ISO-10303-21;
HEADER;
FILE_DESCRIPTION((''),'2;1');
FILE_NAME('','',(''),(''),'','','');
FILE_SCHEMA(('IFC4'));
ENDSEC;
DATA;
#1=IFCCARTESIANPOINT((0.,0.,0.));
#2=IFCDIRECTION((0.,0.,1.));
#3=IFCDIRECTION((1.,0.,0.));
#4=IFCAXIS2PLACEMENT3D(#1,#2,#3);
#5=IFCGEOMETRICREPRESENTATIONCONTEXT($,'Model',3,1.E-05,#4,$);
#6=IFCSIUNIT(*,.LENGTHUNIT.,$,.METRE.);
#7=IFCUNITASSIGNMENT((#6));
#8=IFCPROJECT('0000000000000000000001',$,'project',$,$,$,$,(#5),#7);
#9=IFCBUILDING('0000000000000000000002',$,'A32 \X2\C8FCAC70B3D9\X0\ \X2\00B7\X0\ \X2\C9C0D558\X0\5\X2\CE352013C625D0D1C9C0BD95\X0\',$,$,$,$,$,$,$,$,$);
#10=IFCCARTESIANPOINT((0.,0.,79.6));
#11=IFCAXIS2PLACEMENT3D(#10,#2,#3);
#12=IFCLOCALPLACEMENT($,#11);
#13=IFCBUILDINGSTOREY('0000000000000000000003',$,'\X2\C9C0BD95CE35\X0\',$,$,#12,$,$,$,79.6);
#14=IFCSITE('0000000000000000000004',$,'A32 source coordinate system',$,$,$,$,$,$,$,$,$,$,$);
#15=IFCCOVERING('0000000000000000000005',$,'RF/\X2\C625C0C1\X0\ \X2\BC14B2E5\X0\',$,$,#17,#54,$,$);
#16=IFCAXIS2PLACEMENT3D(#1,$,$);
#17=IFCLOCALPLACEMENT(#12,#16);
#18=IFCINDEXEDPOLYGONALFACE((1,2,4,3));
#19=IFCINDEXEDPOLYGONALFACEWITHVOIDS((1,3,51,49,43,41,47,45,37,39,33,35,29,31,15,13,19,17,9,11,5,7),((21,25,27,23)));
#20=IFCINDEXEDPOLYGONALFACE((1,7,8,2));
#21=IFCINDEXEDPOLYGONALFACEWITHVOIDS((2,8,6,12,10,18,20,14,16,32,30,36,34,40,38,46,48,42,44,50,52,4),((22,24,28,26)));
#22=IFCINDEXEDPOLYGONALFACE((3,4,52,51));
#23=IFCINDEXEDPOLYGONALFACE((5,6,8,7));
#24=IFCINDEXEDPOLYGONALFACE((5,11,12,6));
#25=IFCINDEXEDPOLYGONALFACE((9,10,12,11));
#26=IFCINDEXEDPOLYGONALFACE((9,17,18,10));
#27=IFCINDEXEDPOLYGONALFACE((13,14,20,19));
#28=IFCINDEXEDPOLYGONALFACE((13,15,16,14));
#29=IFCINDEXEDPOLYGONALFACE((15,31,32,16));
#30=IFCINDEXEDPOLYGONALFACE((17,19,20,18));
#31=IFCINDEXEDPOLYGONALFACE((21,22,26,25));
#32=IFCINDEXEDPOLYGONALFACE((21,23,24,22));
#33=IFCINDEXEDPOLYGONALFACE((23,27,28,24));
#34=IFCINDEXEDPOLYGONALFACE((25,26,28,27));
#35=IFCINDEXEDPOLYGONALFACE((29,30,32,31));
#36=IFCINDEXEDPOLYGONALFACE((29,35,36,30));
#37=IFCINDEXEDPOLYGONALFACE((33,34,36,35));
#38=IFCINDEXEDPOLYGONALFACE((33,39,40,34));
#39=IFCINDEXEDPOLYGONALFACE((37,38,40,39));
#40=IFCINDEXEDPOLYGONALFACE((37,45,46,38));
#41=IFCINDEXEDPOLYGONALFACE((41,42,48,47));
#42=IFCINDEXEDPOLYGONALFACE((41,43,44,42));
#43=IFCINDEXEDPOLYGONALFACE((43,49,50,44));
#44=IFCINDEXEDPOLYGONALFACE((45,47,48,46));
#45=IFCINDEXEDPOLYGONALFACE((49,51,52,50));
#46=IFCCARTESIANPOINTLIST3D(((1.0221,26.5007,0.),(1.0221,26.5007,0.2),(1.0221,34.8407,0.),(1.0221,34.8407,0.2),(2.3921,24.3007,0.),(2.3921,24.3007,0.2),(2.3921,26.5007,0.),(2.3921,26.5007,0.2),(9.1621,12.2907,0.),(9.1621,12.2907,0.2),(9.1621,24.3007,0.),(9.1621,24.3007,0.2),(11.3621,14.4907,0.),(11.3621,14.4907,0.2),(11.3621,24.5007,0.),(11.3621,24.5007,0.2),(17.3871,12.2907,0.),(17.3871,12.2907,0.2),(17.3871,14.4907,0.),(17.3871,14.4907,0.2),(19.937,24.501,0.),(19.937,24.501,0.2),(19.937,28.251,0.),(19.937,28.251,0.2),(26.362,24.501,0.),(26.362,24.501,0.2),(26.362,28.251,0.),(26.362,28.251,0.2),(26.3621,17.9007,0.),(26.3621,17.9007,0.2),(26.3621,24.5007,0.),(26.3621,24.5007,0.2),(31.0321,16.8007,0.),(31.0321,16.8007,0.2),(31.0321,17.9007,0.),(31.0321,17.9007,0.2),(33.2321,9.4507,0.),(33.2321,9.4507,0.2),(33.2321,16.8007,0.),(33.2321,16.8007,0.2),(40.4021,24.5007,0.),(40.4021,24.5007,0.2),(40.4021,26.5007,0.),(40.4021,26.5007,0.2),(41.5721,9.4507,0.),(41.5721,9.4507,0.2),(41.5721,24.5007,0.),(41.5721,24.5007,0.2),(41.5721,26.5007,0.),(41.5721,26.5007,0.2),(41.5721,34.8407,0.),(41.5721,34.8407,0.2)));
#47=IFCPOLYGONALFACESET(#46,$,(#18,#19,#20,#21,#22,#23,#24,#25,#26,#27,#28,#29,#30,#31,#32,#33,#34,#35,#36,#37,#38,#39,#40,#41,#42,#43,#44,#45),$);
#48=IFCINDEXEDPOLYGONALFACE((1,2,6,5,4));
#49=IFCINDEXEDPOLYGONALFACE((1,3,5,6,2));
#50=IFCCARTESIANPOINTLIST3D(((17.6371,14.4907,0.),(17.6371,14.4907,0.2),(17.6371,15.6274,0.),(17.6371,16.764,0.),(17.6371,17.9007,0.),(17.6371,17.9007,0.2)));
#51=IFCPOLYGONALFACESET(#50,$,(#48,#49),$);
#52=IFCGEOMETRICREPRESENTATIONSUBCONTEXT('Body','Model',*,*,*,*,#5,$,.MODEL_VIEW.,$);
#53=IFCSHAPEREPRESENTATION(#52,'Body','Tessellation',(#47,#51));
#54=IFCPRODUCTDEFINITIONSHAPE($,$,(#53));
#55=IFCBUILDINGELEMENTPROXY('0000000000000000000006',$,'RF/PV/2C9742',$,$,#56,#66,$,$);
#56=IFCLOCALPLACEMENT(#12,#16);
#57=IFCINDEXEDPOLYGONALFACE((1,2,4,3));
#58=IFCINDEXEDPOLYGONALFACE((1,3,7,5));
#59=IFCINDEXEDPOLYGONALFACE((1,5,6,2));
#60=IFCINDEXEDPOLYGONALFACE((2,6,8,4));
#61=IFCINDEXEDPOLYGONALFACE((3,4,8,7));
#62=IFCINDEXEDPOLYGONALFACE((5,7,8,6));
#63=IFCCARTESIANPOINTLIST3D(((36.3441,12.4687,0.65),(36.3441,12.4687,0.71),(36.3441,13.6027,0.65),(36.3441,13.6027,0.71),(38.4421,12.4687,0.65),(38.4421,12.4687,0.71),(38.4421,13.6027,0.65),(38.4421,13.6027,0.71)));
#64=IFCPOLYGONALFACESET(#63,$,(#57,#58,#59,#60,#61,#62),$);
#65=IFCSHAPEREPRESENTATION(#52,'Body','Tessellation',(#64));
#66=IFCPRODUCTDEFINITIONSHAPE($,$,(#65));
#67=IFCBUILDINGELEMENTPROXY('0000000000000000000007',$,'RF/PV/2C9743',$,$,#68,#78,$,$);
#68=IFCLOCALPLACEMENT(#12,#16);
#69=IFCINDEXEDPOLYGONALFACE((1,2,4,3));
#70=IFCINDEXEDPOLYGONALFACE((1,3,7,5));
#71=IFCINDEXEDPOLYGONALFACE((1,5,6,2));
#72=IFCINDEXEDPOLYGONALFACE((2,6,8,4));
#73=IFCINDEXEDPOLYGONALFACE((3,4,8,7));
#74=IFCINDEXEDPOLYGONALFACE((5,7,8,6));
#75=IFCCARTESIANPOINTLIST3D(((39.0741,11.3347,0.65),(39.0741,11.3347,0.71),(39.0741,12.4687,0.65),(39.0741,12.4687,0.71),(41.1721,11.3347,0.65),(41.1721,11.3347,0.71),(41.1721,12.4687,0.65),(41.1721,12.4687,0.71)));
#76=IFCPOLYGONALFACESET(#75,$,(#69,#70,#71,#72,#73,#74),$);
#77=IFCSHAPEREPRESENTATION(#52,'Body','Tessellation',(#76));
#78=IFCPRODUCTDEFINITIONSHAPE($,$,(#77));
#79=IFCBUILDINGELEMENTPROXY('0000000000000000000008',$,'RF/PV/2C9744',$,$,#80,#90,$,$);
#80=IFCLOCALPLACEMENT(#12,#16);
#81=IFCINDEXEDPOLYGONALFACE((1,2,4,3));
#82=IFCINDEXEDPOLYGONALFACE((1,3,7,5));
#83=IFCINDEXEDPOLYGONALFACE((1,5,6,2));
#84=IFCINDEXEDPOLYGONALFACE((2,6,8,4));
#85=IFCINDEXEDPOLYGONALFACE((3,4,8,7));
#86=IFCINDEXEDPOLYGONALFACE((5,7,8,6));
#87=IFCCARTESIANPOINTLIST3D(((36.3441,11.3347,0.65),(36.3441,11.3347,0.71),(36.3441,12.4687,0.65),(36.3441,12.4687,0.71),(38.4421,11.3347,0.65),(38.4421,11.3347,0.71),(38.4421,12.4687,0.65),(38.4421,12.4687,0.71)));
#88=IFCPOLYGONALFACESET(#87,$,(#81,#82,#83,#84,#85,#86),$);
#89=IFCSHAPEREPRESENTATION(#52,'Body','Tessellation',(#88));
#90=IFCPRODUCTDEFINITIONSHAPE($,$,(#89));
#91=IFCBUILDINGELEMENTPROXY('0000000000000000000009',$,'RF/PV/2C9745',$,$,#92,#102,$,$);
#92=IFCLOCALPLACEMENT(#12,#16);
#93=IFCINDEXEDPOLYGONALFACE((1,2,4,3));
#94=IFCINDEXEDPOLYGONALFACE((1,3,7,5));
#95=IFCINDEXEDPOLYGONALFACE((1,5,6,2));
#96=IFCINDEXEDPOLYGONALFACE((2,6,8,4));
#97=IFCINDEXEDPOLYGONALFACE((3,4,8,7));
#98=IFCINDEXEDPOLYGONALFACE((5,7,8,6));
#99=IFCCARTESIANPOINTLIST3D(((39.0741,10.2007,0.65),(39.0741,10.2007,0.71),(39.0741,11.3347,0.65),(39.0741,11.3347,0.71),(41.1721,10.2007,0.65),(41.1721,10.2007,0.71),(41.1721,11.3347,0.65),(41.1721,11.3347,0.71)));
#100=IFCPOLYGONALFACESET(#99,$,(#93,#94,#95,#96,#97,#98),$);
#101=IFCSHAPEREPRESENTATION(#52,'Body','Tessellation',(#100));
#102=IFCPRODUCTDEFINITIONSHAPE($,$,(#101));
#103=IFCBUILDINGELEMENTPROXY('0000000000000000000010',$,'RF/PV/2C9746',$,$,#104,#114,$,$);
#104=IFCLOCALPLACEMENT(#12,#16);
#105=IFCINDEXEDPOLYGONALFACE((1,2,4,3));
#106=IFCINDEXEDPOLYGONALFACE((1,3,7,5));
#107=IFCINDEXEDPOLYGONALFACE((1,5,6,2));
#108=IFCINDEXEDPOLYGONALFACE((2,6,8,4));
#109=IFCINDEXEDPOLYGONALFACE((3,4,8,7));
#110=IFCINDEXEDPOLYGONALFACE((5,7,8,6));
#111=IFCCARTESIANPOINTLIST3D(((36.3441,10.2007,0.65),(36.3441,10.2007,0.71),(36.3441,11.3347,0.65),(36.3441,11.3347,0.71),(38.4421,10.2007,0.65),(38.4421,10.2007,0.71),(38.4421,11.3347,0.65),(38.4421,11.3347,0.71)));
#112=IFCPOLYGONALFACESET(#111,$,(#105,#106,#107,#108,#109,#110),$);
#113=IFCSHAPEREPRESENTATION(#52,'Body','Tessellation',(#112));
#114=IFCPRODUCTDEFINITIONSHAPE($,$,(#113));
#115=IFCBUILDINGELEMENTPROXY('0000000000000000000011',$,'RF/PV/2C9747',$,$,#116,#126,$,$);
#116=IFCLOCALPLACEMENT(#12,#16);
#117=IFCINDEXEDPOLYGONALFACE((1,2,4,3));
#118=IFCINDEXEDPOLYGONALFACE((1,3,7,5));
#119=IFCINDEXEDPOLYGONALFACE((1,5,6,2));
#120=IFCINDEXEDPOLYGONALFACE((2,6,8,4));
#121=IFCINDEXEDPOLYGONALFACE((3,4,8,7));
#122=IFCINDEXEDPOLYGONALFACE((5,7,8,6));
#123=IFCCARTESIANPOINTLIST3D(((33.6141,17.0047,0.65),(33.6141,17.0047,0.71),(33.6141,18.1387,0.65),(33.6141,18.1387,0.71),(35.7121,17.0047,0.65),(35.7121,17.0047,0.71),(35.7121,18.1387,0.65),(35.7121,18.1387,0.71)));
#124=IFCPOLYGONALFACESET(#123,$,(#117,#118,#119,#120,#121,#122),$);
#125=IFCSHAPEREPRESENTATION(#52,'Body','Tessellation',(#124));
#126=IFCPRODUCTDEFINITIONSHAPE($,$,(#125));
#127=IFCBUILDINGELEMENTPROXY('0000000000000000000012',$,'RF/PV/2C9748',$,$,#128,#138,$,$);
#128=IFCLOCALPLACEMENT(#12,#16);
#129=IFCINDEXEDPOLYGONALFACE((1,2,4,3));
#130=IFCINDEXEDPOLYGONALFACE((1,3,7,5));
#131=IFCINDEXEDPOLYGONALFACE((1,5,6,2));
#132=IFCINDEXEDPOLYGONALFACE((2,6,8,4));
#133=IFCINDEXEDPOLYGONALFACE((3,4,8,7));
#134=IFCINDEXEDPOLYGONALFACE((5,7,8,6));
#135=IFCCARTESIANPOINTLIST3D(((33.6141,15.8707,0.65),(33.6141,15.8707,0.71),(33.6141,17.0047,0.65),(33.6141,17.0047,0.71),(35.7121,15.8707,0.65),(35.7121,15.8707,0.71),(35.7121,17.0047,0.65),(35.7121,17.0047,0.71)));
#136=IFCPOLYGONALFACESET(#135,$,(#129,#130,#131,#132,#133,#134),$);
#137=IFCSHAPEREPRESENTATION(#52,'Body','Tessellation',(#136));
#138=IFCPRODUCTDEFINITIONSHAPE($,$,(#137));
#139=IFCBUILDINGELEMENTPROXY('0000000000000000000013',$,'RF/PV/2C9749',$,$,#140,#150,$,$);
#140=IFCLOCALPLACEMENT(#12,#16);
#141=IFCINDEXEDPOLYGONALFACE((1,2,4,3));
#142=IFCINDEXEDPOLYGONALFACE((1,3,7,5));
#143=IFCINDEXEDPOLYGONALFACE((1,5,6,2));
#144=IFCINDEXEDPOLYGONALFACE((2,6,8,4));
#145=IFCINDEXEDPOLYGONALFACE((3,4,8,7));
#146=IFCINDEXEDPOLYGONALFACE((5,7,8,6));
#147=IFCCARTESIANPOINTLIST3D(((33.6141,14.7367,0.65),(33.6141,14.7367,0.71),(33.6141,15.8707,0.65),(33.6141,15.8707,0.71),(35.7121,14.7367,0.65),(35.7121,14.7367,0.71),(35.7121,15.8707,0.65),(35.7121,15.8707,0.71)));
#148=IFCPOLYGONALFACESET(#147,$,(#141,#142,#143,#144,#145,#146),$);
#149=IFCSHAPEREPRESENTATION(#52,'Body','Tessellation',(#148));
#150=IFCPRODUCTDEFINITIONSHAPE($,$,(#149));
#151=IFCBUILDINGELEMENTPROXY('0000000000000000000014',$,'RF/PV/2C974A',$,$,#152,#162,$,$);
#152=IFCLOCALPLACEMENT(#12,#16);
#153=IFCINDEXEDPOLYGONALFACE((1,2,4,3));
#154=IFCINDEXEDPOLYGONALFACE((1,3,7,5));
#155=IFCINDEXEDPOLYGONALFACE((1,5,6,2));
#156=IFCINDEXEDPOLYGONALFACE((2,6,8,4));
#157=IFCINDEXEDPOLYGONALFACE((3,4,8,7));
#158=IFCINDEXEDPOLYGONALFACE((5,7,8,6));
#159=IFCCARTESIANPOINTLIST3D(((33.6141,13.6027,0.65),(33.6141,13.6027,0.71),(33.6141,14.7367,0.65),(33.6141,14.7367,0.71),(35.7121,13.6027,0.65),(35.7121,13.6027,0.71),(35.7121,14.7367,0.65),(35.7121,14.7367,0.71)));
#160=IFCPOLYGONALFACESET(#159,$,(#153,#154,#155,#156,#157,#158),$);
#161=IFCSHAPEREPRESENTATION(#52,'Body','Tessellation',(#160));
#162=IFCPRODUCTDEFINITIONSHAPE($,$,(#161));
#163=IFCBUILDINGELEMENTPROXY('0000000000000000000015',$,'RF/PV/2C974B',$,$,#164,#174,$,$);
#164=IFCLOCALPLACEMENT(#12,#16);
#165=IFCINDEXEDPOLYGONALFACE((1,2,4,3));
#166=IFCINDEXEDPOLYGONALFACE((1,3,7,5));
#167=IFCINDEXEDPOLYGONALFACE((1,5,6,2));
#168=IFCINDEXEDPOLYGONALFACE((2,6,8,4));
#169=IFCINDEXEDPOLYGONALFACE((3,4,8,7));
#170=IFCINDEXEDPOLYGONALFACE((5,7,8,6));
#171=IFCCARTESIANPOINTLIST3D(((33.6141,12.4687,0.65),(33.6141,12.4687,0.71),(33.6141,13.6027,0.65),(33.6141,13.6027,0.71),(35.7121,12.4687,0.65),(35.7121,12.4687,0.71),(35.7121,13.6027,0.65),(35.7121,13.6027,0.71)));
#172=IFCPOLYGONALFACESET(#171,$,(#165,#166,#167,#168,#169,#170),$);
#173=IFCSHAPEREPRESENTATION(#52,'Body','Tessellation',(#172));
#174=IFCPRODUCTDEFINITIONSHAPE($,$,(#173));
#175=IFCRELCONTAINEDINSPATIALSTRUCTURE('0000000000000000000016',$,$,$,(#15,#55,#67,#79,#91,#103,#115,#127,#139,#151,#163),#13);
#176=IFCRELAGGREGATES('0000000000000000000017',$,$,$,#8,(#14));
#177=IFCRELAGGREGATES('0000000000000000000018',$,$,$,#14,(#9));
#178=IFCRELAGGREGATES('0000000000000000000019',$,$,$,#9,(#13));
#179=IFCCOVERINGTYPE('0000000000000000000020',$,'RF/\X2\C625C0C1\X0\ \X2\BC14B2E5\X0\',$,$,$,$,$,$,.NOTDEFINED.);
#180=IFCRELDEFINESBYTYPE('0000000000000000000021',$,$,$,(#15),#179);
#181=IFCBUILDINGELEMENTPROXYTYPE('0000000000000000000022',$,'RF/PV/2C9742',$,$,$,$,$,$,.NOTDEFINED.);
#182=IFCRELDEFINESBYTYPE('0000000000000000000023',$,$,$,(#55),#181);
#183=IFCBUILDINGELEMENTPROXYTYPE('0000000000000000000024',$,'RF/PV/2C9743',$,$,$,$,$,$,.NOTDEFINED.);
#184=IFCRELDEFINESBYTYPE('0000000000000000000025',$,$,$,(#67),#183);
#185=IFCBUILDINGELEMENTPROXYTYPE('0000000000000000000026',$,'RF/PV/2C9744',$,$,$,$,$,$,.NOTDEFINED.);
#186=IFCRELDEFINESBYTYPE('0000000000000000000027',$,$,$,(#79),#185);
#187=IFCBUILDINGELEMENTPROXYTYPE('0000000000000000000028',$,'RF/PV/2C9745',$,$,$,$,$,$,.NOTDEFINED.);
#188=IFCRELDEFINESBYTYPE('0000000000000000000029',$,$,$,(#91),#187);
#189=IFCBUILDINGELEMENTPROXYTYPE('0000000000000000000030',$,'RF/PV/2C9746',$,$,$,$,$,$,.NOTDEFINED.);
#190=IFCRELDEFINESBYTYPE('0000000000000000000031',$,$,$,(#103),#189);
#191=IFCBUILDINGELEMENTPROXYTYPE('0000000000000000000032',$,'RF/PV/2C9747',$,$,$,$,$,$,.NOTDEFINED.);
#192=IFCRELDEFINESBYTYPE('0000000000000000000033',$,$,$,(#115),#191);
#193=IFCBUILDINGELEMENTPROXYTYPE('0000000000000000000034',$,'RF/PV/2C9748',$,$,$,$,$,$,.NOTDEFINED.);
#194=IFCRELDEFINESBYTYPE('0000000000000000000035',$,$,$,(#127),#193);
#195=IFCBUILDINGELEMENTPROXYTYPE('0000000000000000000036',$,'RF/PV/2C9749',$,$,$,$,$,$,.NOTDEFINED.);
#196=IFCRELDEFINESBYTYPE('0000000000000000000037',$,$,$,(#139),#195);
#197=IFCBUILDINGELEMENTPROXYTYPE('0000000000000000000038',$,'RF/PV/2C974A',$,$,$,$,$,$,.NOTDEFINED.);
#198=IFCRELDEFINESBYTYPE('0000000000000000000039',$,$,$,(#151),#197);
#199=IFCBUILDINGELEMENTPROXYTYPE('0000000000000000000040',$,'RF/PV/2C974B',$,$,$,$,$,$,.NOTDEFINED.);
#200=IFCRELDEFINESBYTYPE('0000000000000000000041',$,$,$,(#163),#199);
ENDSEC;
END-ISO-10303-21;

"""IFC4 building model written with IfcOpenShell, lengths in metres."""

from ifc_helpers import new_model, si_unit, frame, origin, origin_with_axes, place, context, subcontext, project, spatial, polyline, outline, extrude, source, transform, mapped, type_object, type_shapes, element, save


model = new_model("IFC4")

# Units and contexts
model_context = context("Model", 3, precision=1e-05, world=origin_with_axes())
body_context = subcontext(model_context, "Body", "Model", "MODEL_VIEW")
ifc_project = project(units=[si_unit("LENGTHUNIT", "METRE")], contexts=[model_context])

# Site, building, storey
site = spatial("IfcSite", under=ifc_project, Name="A32 source coordinate system")
building = spatial("IfcBuilding", under=site, Name="A32 주거동 · 지하5층–옥탑지붕")
storey_placement = place(None, frame((0.0, 0.0, 79.6), z_axis=(0.0, 0.0, 1.0), x_axis=(1.0, 0.0, 0.0)))
storey = spatial("IfcBuildingStorey", under=building, at=storey_placement, Name="지붕층", Elevation=79.6)

# Covering
covering_type = type_object("IfcCoveringType", Name="RF/옥상 바닥", PredefinedType="NOTDEFINED")
shared_shape_1 = source(origin(), body_context, "Body", "SweptSolid", [
    extrude(outline(polyline([(9.1621, 12.2907), (9.1621, 24.3007), (2.3921, 24.3007), (2.3921, 26.5007), (1.0221, 26.5007), (1.0221, 34.8407), (41.5721, 34.8407), (41.5721, 26.5007), (40.4021, 26.5007), (40.4021, 24.5007), (41.5721, 24.5007), (41.5721, 9.4507), (33.2321, 9.4507), (33.2321, 16.8007), (31.0321, 16.8007), (31.0321, 17.9007), (26.3621, 17.9007), (26.3621, 17.9007), (26.3621, 24.5007), (11.3621, 24.5007), (11.3621, 14.4907), (17.3871, 14.4907), (17.3871, 14.4907), (17.3871, 12.2907), (9.1621, 12.2907)]), holes=[polyline([(26.362, 28.251), (19.937, 28.251), (19.937, 24.501), (26.362, 24.501), (26.362, 28.251)])]), origin(), (0.0, 0.0, 1.0), 0.2),
    extrude(outline(polyline([(17.6371, 14.4907), (17.6371, 17.9007), (17.6371, 17.9007), (17.6371, 14.4907), (17.6371, 14.4907)])), origin(), (0.0, 0.0, 1.0), 0.2),
])
type_shapes(covering_type, [shared_shape_1])
covering_placement = place(storey_placement, origin_with_axes())
element("IfcCovering", 1, at=covering_placement, inside=storey, type_object=covering_type, Name="RF/옥상 바닥", context=body_context, shape_type="MappedRepresentation", body=[
    mapped(shared_shape_1, transform((0.0, 0.0, 0.0), scale=1.0)),
])

# Building element proxies
building_element_proxy_type_1 = type_object("IfcBuildingElementProxyType", Name="RF/PV/2C9742", PredefinedType="NOTDEFINED")
shared_shape_2 = source(origin(), body_context, "Body", "SweptSolid", [
    extrude(outline(polyline([(38.4421, 13.6027), (38.4421, 12.4687), (36.3441, 12.4687), (36.3441, 13.6027), (38.4421, 13.6027)])), frame((0.0, 0.0, 0.65)), (0.0, 0.0, 1.0), 0.06),
])
type_shapes(building_element_proxy_type_1, [shared_shape_2])
proxy_1_placement = place(storey_placement, origin_with_axes())
element("IfcBuildingElementProxy", 2, at=proxy_1_placement, inside=storey, type_object=building_element_proxy_type_1, Name="RF/PV/2C9742", context=body_context, shape_type="MappedRepresentation", body=[
    mapped(shared_shape_2, transform((0.0, 0.0, 0.0), scale=1.0)),
])
building_element_proxy_type_2 = type_object("IfcBuildingElementProxyType", Name="RF/PV/2C9743", PredefinedType="NOTDEFINED")
shared_shape_3 = source(origin(), body_context, "Body", "SweptSolid", [
    extrude(outline(polyline([(41.1721, 12.4687), (41.1721, 11.3347), (39.0741, 11.3347), (39.0741, 12.4687), (41.1721, 12.4687)])), frame((0.0, 0.0, 0.65)), (0.0, 0.0, 1.0), 0.06),
])
type_shapes(building_element_proxy_type_2, [shared_shape_3])
proxy_2_placement = place(storey_placement, origin_with_axes())
element("IfcBuildingElementProxy", 3, at=proxy_2_placement, inside=storey, type_object=building_element_proxy_type_2, Name="RF/PV/2C9743", context=body_context, shape_type="MappedRepresentation", body=[
    mapped(shared_shape_3, transform((0.0, 0.0, 0.0), scale=1.0)),
])
building_element_proxy_type_3 = type_object("IfcBuildingElementProxyType", Name="RF/PV/2C9744", PredefinedType="NOTDEFINED")
shared_shape_4 = source(origin(), body_context, "Body", "SweptSolid", [
    extrude(outline(polyline([(38.4421, 12.4687), (38.4421, 11.3347), (36.3441, 11.3347), (36.3441, 12.4687), (38.4421, 12.4687)])), frame((0.0, 0.0, 0.65)), (0.0, 0.0, 1.0), 0.06),
])
type_shapes(building_element_proxy_type_3, [shared_shape_4])
proxy_3_placement = place(storey_placement, origin_with_axes())
element("IfcBuildingElementProxy", 4, at=proxy_3_placement, inside=storey, type_object=building_element_proxy_type_3, Name="RF/PV/2C9744", context=body_context, shape_type="MappedRepresentation", body=[
    mapped(shared_shape_4, transform((0.0, 0.0, 0.0), scale=1.0)),
])
building_element_proxy_type_4 = type_object("IfcBuildingElementProxyType", Name="RF/PV/2C9745", PredefinedType="NOTDEFINED")
shared_shape_5 = source(origin(), body_context, "Body", "SweptSolid", [
    extrude(outline(polyline([(41.1721, 11.3347), (41.1721, 10.2007), (39.0741, 10.2007), (39.0741, 11.3347), (41.1721, 11.3347)])), frame((0.0, 0.0, 0.65)), (0.0, 0.0, 1.0), 0.06),
])
type_shapes(building_element_proxy_type_4, [shared_shape_5])
proxy_4_placement = place(storey_placement, origin_with_axes())
element("IfcBuildingElementProxy", 5, at=proxy_4_placement, inside=storey, type_object=building_element_proxy_type_4, Name="RF/PV/2C9745", context=body_context, shape_type="MappedRepresentation", body=[
    mapped(shared_shape_5, transform((0.0, 0.0, 0.0), scale=1.0)),
])
building_element_proxy_type_5 = type_object("IfcBuildingElementProxyType", Name="RF/PV/2C9746", PredefinedType="NOTDEFINED")
shared_shape_6 = source(origin(), body_context, "Body", "SweptSolid", [
    extrude(outline(polyline([(38.4421, 11.3347), (38.4421, 10.2007), (36.3441, 10.2007), (36.3441, 11.3347), (38.4421, 11.3347)])), frame((0.0, 0.0, 0.65)), (0.0, 0.0, 1.0), 0.06),
])
type_shapes(building_element_proxy_type_5, [shared_shape_6])
proxy_5_placement = place(storey_placement, origin_with_axes())
element("IfcBuildingElementProxy", 6, at=proxy_5_placement, inside=storey, type_object=building_element_proxy_type_5, Name="RF/PV/2C9746", context=body_context, shape_type="MappedRepresentation", body=[
    mapped(shared_shape_6, transform((0.0, 0.0, 0.0), scale=1.0)),
])
building_element_proxy_type_6 = type_object("IfcBuildingElementProxyType", Name="RF/PV/2C9747", PredefinedType="NOTDEFINED")
shared_shape_7 = source(origin(), body_context, "Body", "SweptSolid", [
    extrude(outline(polyline([(35.7121, 18.1387), (35.7121, 17.0047), (33.6141, 17.0047), (33.6141, 18.1387), (35.7121, 18.1387)])), frame((0.0, 0.0, 0.65)), (0.0, 0.0, 1.0), 0.06),
])
type_shapes(building_element_proxy_type_6, [shared_shape_7])
proxy_6_placement = place(storey_placement, origin_with_axes())
element("IfcBuildingElementProxy", 7, at=proxy_6_placement, inside=storey, type_object=building_element_proxy_type_6, Name="RF/PV/2C9747", context=body_context, shape_type="MappedRepresentation", body=[
    mapped(shared_shape_7, transform((0.0, 0.0, 0.0), scale=1.0)),
])
building_element_proxy_type_7 = type_object("IfcBuildingElementProxyType", Name="RF/PV/2C9748", PredefinedType="NOTDEFINED")
shared_shape_8 = source(origin(), body_context, "Body", "SweptSolid", [
    extrude(outline(polyline([(35.7121, 17.0047), (35.7121, 15.8707), (33.6141, 15.8707), (33.6141, 17.0047), (35.7121, 17.0047)])), frame((0.0, 0.0, 0.65)), (0.0, 0.0, 1.0), 0.06),
])
type_shapes(building_element_proxy_type_7, [shared_shape_8])
proxy_7_placement = place(storey_placement, origin_with_axes())
element("IfcBuildingElementProxy", 8, at=proxy_7_placement, inside=storey, type_object=building_element_proxy_type_7, Name="RF/PV/2C9748", context=body_context, shape_type="MappedRepresentation", body=[
    mapped(shared_shape_8, transform((0.0, 0.0, 0.0), scale=1.0)),
])
building_element_proxy_type_8 = type_object("IfcBuildingElementProxyType", Name="RF/PV/2C9749", PredefinedType="NOTDEFINED")
shared_shape_9 = source(origin(), body_context, "Body", "SweptSolid", [
    extrude(outline(polyline([(35.7121, 15.8707), (35.7121, 14.7367), (33.6141, 14.7367), (33.6141, 15.8707), (35.7121, 15.8707)])), frame((0.0, 0.0, 0.65)), (0.0, 0.0, 1.0), 0.06),
])
type_shapes(building_element_proxy_type_8, [shared_shape_9])
proxy_8_placement = place(storey_placement, origin_with_axes())
element("IfcBuildingElementProxy", 9, at=proxy_8_placement, inside=storey, type_object=building_element_proxy_type_8, Name="RF/PV/2C9749", context=body_context, shape_type="MappedRepresentation", body=[
    mapped(shared_shape_9, transform((0.0, 0.0, 0.0), scale=1.0)),
])
building_element_proxy_type_9 = type_object("IfcBuildingElementProxyType", Name="RF/PV/2C974A", PredefinedType="NOTDEFINED")
shared_shape_10 = source(origin(), body_context, "Body", "SweptSolid", [
    extrude(outline(polyline([(35.7121, 14.7367), (35.7121, 13.6027), (33.6141, 13.6027), (33.6141, 14.7367), (35.7121, 14.7367)])), frame((0.0, 0.0, 0.65)), (0.0, 0.0, 1.0), 0.06),
])
type_shapes(building_element_proxy_type_9, [shared_shape_10])
proxy_9_placement = place(storey_placement, origin_with_axes())
element("IfcBuildingElementProxy", 10, at=proxy_9_placement, inside=storey, type_object=building_element_proxy_type_9, Name="RF/PV/2C974A", context=body_context, shape_type="MappedRepresentation", body=[
    mapped(shared_shape_10, transform((0.0, 0.0, 0.0), scale=1.0)),
])
building_element_proxy_type_10 = type_object("IfcBuildingElementProxyType", Name="RF/PV/2C974B", PredefinedType="NOTDEFINED")
shared_shape_11 = source(origin(), body_context, "Body", "SweptSolid", [
    extrude(outline(polyline([(35.7121, 13.6027), (35.7121, 12.4687), (33.6141, 12.4687), (33.6141, 13.6027), (35.7121, 13.6027)])), frame((0.0, 0.0, 0.65)), (0.0, 0.0, 1.0), 0.06),
])
type_shapes(building_element_proxy_type_10, [shared_shape_11])
proxy_10_placement = place(storey_placement, origin_with_axes())
element("IfcBuildingElementProxy", 11, at=proxy_10_placement, inside=storey, type_object=building_element_proxy_type_10, Name="RF/PV/2C974B", context=body_context, shape_type="MappedRepresentation", body=[
    mapped(shared_shape_11, transform((0.0, 0.0, 0.0), scale=1.0)),
])

save(model, "model.ifc")
